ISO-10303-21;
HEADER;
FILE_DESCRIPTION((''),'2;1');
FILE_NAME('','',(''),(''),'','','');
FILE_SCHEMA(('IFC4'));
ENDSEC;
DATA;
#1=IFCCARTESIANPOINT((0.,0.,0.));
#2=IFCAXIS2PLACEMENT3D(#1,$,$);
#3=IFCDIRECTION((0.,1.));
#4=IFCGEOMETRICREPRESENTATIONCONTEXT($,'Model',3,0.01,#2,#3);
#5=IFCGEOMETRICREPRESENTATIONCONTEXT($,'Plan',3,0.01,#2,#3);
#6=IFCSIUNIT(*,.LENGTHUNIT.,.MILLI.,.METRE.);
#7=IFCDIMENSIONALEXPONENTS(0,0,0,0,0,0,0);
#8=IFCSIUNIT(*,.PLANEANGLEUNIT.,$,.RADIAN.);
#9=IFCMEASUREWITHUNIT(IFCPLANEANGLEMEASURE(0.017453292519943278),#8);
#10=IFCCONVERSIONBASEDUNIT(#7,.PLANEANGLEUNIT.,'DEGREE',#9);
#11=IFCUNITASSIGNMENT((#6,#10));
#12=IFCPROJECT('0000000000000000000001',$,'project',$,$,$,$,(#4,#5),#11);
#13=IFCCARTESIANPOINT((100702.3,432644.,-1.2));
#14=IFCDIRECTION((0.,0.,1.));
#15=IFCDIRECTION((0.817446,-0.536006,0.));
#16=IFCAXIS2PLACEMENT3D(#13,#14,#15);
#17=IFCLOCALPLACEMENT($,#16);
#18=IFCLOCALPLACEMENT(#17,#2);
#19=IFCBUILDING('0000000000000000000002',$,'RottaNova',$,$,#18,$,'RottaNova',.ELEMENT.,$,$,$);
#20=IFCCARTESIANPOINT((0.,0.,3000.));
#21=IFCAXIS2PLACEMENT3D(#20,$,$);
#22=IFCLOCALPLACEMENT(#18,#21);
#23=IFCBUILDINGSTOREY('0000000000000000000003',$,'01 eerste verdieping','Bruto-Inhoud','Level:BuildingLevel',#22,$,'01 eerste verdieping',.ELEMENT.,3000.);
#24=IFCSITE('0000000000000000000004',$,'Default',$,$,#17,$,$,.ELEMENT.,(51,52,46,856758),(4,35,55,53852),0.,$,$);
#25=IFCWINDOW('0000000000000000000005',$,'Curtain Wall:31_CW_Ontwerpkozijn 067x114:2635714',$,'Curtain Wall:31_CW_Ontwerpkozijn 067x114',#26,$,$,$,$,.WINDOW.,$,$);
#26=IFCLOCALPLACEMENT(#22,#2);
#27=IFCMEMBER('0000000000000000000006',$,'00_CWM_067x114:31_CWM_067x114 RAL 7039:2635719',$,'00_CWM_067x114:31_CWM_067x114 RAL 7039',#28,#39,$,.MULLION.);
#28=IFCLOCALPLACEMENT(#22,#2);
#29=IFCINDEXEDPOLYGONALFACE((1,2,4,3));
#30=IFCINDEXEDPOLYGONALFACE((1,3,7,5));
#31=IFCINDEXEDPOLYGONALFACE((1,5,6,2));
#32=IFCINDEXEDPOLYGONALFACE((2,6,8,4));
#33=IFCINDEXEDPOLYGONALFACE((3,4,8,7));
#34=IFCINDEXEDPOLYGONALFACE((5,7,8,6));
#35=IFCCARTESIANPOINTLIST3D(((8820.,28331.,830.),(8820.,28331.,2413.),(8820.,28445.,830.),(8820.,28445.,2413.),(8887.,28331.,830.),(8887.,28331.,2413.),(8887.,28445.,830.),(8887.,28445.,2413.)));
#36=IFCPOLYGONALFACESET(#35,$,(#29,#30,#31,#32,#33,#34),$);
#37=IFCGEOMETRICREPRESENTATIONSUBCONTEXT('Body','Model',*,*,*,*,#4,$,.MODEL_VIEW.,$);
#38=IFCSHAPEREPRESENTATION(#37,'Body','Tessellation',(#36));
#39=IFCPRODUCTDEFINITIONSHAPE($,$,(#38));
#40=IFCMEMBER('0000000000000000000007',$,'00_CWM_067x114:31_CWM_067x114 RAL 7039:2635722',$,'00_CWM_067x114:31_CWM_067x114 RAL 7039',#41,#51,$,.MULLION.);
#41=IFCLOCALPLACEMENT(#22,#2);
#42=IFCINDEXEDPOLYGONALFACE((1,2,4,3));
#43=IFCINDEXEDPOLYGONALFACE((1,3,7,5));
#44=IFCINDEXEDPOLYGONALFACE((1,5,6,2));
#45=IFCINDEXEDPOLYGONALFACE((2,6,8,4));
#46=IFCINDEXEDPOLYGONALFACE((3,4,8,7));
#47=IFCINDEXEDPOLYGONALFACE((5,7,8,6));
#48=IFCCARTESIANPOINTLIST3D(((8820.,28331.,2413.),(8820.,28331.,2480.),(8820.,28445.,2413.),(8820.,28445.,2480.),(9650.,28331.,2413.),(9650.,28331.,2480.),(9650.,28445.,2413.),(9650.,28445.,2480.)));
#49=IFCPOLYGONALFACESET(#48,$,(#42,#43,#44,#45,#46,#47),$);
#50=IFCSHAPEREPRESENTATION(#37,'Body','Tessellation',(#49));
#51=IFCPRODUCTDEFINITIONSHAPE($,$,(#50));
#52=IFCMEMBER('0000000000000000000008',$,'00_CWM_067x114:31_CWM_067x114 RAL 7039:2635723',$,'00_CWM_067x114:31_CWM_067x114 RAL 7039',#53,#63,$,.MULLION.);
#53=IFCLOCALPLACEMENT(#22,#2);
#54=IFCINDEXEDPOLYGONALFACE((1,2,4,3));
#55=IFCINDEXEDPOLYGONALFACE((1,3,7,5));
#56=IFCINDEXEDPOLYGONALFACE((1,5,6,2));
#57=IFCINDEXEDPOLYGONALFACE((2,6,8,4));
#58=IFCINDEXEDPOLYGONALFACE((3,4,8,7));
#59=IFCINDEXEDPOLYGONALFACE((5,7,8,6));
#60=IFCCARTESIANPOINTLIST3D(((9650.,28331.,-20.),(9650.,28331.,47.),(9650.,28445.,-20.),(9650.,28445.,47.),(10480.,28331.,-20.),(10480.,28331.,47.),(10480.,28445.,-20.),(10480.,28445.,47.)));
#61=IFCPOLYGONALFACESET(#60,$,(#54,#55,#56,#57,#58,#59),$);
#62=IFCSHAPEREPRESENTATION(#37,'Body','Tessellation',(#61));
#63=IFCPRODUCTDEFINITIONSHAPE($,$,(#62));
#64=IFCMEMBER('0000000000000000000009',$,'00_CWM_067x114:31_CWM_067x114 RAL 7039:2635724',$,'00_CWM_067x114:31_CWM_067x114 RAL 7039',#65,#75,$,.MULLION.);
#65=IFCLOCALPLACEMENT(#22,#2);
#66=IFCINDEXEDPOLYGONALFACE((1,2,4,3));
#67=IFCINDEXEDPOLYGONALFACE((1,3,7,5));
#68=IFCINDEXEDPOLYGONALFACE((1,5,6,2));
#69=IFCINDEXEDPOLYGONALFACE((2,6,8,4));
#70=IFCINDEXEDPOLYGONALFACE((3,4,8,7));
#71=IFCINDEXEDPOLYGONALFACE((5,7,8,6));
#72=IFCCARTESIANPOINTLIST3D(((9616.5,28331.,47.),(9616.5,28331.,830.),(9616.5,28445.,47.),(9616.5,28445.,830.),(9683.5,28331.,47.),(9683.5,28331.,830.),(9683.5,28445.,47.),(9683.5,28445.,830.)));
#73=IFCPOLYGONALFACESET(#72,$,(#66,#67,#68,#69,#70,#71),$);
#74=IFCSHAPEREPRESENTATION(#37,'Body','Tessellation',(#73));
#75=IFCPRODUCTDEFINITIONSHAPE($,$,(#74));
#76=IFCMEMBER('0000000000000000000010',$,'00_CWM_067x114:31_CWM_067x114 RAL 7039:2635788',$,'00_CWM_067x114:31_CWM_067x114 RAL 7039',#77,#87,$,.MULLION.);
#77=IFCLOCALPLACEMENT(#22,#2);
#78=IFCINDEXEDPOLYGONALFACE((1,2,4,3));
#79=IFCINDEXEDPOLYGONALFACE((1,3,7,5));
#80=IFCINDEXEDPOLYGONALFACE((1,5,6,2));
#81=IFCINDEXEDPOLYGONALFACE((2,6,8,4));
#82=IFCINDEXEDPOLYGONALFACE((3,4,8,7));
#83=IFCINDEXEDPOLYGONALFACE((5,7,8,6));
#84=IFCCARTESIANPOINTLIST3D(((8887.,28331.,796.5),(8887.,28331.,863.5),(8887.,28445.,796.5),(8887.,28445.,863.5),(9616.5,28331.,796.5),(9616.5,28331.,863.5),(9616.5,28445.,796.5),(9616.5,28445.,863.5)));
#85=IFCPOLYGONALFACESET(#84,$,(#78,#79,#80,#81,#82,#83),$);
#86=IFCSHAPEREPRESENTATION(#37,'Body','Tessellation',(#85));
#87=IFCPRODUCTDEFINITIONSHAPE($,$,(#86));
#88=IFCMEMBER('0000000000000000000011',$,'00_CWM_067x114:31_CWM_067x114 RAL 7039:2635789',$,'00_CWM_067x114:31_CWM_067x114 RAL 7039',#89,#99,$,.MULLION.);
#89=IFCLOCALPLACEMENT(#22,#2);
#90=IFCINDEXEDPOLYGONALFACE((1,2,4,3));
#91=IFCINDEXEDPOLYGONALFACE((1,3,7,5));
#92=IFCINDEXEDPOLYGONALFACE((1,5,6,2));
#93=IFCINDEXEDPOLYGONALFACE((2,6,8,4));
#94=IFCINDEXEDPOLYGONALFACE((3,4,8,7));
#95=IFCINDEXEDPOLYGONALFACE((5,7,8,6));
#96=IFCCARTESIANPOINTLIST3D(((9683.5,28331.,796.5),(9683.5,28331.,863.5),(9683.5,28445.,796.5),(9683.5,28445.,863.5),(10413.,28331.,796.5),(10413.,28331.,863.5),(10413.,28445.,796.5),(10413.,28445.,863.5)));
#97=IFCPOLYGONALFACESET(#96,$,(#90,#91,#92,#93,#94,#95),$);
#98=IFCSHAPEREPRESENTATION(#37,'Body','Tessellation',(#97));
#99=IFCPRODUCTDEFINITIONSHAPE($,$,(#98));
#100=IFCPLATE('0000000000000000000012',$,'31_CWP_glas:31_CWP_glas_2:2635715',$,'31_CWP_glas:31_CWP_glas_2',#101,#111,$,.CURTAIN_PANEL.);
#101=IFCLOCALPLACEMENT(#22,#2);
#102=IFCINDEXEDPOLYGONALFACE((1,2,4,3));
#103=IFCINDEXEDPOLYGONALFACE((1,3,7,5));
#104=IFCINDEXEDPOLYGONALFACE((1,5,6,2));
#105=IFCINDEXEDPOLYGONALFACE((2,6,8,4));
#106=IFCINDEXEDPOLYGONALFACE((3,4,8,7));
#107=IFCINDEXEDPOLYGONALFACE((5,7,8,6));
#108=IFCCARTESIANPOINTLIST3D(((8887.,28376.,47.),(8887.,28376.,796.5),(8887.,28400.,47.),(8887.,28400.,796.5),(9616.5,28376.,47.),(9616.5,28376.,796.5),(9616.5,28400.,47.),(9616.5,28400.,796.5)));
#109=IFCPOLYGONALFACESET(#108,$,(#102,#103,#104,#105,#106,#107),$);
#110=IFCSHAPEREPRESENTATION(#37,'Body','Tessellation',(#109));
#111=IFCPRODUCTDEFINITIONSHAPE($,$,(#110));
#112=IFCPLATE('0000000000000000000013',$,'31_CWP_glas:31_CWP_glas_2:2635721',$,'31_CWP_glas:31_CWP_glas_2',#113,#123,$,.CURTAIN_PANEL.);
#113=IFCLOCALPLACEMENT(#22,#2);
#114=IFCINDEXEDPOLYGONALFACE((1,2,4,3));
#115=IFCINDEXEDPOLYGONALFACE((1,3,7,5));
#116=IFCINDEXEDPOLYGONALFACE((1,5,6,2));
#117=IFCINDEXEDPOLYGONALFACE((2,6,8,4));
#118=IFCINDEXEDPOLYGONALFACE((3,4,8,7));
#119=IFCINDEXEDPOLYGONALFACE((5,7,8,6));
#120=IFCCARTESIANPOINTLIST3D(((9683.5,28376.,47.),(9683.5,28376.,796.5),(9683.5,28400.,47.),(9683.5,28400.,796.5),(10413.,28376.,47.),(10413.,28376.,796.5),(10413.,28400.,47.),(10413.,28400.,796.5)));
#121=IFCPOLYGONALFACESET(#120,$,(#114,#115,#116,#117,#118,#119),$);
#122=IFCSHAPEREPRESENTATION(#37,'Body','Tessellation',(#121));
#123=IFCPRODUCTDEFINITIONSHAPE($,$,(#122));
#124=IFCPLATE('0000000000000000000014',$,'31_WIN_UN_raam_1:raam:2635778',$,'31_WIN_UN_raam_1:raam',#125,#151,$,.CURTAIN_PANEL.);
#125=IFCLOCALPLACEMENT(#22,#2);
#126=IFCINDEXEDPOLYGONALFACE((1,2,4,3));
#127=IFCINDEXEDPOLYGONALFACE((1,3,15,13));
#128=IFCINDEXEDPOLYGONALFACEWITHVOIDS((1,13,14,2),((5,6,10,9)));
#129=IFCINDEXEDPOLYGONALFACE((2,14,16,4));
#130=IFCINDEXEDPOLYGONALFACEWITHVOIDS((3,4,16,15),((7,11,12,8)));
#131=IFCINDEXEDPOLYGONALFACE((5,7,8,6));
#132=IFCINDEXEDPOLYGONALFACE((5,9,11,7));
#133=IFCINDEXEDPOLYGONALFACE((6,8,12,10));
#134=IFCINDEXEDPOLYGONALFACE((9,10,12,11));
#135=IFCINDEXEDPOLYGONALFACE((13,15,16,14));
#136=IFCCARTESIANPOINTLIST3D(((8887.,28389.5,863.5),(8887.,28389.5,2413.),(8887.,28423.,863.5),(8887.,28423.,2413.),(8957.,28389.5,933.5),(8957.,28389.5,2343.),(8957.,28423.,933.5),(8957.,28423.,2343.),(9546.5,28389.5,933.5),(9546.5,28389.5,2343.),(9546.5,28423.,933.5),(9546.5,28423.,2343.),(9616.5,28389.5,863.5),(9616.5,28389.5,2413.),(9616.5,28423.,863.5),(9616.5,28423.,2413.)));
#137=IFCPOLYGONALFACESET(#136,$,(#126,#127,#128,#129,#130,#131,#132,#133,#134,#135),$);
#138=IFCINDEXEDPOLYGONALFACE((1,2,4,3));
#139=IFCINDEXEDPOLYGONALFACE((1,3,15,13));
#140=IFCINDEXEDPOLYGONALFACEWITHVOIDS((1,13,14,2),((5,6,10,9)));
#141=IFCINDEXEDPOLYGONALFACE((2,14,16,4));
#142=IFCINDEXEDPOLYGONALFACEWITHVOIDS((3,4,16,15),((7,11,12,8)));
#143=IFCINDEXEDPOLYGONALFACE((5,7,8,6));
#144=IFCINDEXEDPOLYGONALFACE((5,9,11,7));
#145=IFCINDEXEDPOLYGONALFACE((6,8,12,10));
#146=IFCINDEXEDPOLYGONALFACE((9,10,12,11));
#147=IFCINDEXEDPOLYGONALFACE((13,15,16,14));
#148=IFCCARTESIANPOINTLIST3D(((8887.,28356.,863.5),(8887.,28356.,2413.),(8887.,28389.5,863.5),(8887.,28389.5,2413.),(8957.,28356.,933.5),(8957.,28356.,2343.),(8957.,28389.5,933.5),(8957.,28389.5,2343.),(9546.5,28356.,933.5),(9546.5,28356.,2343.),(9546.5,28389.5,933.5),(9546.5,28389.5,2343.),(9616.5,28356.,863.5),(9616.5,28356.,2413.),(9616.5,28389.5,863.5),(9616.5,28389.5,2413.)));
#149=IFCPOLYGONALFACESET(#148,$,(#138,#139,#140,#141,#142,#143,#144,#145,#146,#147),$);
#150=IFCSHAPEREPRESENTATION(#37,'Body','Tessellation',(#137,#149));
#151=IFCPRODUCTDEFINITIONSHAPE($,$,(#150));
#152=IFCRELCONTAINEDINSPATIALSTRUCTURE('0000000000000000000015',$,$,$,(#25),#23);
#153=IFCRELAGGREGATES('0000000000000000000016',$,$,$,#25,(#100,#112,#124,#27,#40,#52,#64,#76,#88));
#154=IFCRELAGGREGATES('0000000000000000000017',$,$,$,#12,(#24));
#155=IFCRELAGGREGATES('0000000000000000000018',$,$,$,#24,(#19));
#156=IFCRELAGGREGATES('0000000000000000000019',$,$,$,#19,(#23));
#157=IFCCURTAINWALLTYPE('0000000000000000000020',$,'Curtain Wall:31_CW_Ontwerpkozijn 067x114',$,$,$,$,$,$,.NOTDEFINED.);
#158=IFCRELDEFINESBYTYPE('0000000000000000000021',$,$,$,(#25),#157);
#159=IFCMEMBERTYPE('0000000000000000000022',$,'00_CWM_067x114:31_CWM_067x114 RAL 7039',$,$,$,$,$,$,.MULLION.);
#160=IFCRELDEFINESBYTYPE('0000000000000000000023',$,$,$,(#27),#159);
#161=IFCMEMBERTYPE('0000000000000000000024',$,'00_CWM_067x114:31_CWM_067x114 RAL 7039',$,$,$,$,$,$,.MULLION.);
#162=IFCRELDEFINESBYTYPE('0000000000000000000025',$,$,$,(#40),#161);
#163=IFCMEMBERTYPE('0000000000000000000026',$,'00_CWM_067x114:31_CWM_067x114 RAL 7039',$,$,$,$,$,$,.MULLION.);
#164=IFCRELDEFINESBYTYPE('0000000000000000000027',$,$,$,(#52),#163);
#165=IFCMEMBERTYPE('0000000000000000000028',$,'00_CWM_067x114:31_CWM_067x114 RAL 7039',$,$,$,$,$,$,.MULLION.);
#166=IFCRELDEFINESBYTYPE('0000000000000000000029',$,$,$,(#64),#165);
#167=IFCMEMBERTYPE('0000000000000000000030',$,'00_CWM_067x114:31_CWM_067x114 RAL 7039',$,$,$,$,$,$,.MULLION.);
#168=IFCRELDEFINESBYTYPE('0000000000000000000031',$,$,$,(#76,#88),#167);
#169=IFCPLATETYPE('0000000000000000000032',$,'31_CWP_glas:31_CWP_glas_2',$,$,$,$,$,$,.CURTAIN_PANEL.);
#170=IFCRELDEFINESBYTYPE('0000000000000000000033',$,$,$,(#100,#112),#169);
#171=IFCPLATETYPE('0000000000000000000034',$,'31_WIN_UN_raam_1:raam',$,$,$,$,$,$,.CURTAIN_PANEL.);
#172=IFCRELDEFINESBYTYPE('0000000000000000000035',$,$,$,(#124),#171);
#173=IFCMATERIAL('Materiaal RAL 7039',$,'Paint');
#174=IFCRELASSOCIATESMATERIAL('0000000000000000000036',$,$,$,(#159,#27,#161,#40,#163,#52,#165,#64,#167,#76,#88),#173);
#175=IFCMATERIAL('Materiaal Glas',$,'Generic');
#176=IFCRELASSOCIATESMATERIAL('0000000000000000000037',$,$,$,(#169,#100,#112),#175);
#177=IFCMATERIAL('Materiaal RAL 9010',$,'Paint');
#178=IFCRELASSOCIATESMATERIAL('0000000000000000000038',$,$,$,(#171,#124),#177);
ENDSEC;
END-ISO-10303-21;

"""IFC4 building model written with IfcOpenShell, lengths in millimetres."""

from ifc_helpers import new_model, entity, si_unit, converted_unit, direction, frame, origin, place, context, subcontext, project, spatial, indexed_curve, outline, extrude, source, transform, mapped, material, type_object, type_shapes, element, aggregate, save


model = new_model("IFC4")

# Units and contexts
model_context = context("Model", 3, precision=0.01, world=origin(), true_north=direction((0.0, 1.0)))
plan_context = context("Plan", 3, precision=0.01, world=origin(), true_north=direction((0.0, 1.0)))
body_context = subcontext(model_context, "Body", "Model", "MODEL_VIEW")
ifc_project = project(units=[si_unit("LENGTHUNIT", "METRE", prefix="MILLI"), converted_unit("PLANEANGLEUNIT", "DEGREE", entity("IfcPlaneAngleMeasure", 0.017453292519943278), si_unit("PLANEANGLEUNIT", "RADIAN"), dimensions=[0, 0, 0, 0, 0, 0, 0])], contexts=[model_context, plan_context])

# Site, building, storey
site_placement = place(None, frame((100702.3, 432644.0, -1.2), z_axis=(0.0, 0.0, 1.0), x_axis=(0.817446, -0.536006, 0.0)))
site = spatial("IfcSite", under=ifc_project, at=site_placement, Name="Default", CompositionType="ELEMENT", RefLatitude=(51, 52, 46, 856758), RefLongitude=(4, 35, 55, 53852), RefElevation=0.0)
building_placement = place(site_placement, origin())
building = spatial("IfcBuilding", under=site, at=building_placement, Name="RottaNova", LongName="RottaNova", CompositionType="ELEMENT")
storey_placement = place(building_placement, frame((0.0, 0.0, 3000.0)))
storey = spatial("IfcBuildingStorey", under=building, at=storey_placement, Name="01 eerste verdieping", Description="Bruto-Inhoud", ObjectType="Level:BuildingLevel", LongName="01 eerste verdieping", CompositionType="ELEMENT", Elevation=3000.0)

# Shared definitions
curtain_wall_type = type_object("IfcCurtainWallType", Name="Curtain Wall:31_CW_Ontwerpkozijn 067x114", PredefinedType="NOTDEFINED")
ifc_material_1 = material(Name="Materiaal RAL 7039", Category="Paint")

# Window
window_1_placement = place(storey_placement, frame((0.0, 0.0, -3000.0)))
window_1 = element("IfcWindow", 1, at=window_1_placement, inside=storey, type_object=curtain_wall_type, Name="Curtain Wall:31_CW_Ontwerpkozijn 067x114:2635714", ObjectType="Curtain Wall:31_CW_Ontwerpkozijn 067x114", PredefinedType="WINDOW")

# Members
member_type_1 = type_object("IfcMemberType", Name="00_CWM_067x114:31_CWM_067x114 RAL 7039", PredefinedType="MULLION", material=ifc_material_1)
shared_shape_1 = source(origin(), body_context, "Body", "SweptSolid", [
    extrude(outline(indexed_curve([(-33.5, -57.0), (33.5, -57.0), (33.5, 57.0), (-33.5, 57.0), (-33.5, -57.0)], self_intersect=False)), frame((-33.5, -57.0, -1583.0), z_axis=(0.0, 0.0, 1.0), x_axis=(-1.0, 0.0, 0.0)), (0.0, 0.0, 1.0), 1583.0),
])
type_shapes(member_type_1, [shared_shape_1])
member_1_placement = place(window_1_placement, frame((8820.0, 28331.0, 5413.0), z_axis=(0.0, 0.0, 1.0), x_axis=(-1.0, 0.0, 0.0)))
member_1 = element("IfcMember", 2, at=member_1_placement, type_object=member_type_1, material=ifc_material_1, Name="00_CWM_067x114:31_CWM_067x114 RAL 7039:2635719", ObjectType="00_CWM_067x114:31_CWM_067x114 RAL 7039", PredefinedType="MULLION", context=body_context, shape_type="MappedRepresentation", body=[
    mapped(shared_shape_1, transform((0.0, 0.0, 0.0), scale=1.0)),
])
member_type_2 = type_object("IfcMemberType", Name="00_CWM_067x114:31_CWM_067x114 RAL 7039", PredefinedType="MULLION", material=ifc_material_1)
shared_shape_2 = source(origin(), body_context, "Body", "SweptSolid", [
    extrude(outline(indexed_curve([(-33.5, -57.0), (33.5, -57.0), (33.5, 57.0), (-33.5, 57.0), (-33.5, -57.0)], self_intersect=False)), frame((-33.5, -57.0, -830.0), z_axis=(0.0, 0.0, 1.0), x_axis=(-1.0, 0.0, 0.0)), (0.0, 0.0, 1.0), 830.0),
])
type_shapes(member_type_2, [shared_shape_2])
member_2_placement = place(window_1_placement, frame((9650.0, 28331.0, 5480.0), z_axis=(1.0, 0.0, 0.0), x_axis=(0.0, 0.0, 1.0)))
member_2 = element("IfcMember", 3, at=member_2_placement, type_object=member_type_2, material=ifc_material_1, Name="00_CWM_067x114:31_CWM_067x114 RAL 7039:2635722", ObjectType="00_CWM_067x114:31_CWM_067x114 RAL 7039", PredefinedType="MULLION", context=body_context, shape_type="MappedRepresentation", body=[
    mapped(shared_shape_2, transform((0.0, 0.0, 0.0), scale=1.0)),
])
member_type_3 = type_object("IfcMemberType", Name="00_CWM_067x114:31_CWM_067x114 RAL 7039", PredefinedType="MULLION", material=ifc_material_1)
shared_shape_3 = source(origin(), body_context, "Body", "SweptSolid", [
    extrude(outline(indexed_curve([(-33.5, -57.0), (33.5, -57.0), (33.5, 57.0), (-33.5, 57.0), (-33.5, -57.0)], self_intersect=False)), frame((-33.5, -57.0, -830.0), z_axis=(0.0, 0.0, 1.0), x_axis=(-1.0, 0.0, 0.0)), (0.0, 0.0, 1.0), 830.0),
])
type_shapes(member_type_3, [shared_shape_3])
member_3_placement = place(window_1_placement, frame((9650.0, 28331.0, 2980.0), z_axis=(-1.0, 0.0, 0.0), x_axis=(0.0, 0.0, -1.0)))
member_3 = element("IfcMember", 4, at=member_3_placement, type_object=member_type_3, material=ifc_material_1, Name="00_CWM_067x114:31_CWM_067x114 RAL 7039:2635723", ObjectType="00_CWM_067x114:31_CWM_067x114 RAL 7039", PredefinedType="MULLION", context=body_context, shape_type="MappedRepresentation", body=[
    mapped(shared_shape_3, transform((0.0, 0.0, 0.0), scale=1.0)),
])
member_type_4 = type_object("IfcMemberType", Name="00_CWM_067x114:31_CWM_067x114 RAL 7039", PredefinedType="MULLION", material=ifc_material_1)
shared_shape_4 = source(origin(), body_context, "Body", "SweptSolid", [
    extrude(outline(indexed_curve([(-33.5, -57.0), (33.5, -57.0), (33.5, 57.0), (-33.5, 57.0), (-33.5, -57.0)], self_intersect=False)), frame((0.0, -57.0, -783.0), z_axis=(0.0, 0.0, 1.0), x_axis=(-1.0, 0.0, 0.0)), (0.0, 0.0, 1.0), 783.0),
])
type_shapes(member_type_4, [shared_shape_4])
member_4_placement = place(window_1_placement, frame((9650.0, 28331.0, 3047.0), z_axis=(0.0, 0.0, -1.0), x_axis=(1.0, 0.0, 0.0)))
member_4 = element("IfcMember", 5, at=member_4_placement, type_object=member_type_4, material=ifc_material_1, Name="00_CWM_067x114:31_CWM_067x114 RAL 7039:2635724", ObjectType="00_CWM_067x114:31_CWM_067x114 RAL 7039", PredefinedType="MULLION", context=body_context, shape_type="MappedRepresentation", body=[
    mapped(shared_shape_4, transform((0.0, 0.0, 0.0), scale=1.0)),
])
member_type_5 = type_object("IfcMemberType", Name="00_CWM_067x114:31_CWM_067x114 RAL 7039", PredefinedType="MULLION", material=ifc_material_1)
shared_shape_5 = source(origin(), body_context, "Body", "SweptSolid", [
    extrude(outline(indexed_curve([(-33.5, -57.0), (33.5, -57.0), (33.5, 57.0), (-33.5, 57.0), (-33.5, -57.0)], self_intersect=False)), frame((0.0, -57.0, -729.5), z_axis=(0.0, 0.0, 1.0), x_axis=(-1.0, 0.0, 0.0)), (0.0, 0.0, 1.0), 729.5),
])
type_shapes(member_type_5, [shared_shape_5])
member_5_placement = place(window_1_placement, frame((9616.5, 28331.0, 3830.0), z_axis=(1.0, 0.0, 0.0), x_axis=(0.0, 0.0, 1.0)))
member_5 = element("IfcMember", 6, at=member_5_placement, type_object=member_type_5, material=ifc_material_1, Name="00_CWM_067x114:31_CWM_067x114 RAL 7039:2635788", ObjectType="00_CWM_067x114:31_CWM_067x114 RAL 7039", PredefinedType="MULLION", context=body_context, shape_type="MappedRepresentation", body=[
    mapped(shared_shape_5, transform((0.0, 0.0, 0.0), scale=1.0)),
])
member_6_placement = place(window_1_placement, frame((10413.0, 28331.0, 3830.0), z_axis=(1.0, 0.0, 0.0), x_axis=(0.0, 0.0, 1.0)))
member_6 = element("IfcMember", 7, at=member_6_placement, type_object=member_type_5, material=ifc_material_1, Name="00_CWM_067x114:31_CWM_067x114 RAL 7039:2635789", ObjectType="00_CWM_067x114:31_CWM_067x114 RAL 7039", PredefinedType="MULLION", context=body_context, shape_type="MappedRepresentation", body=[
    mapped(shared_shape_5, transform((0.0, 0.0, 0.0), scale=1.0)),
])

# Plates
ifc_material_2 = material(Name="Materiaal Glas", Category="Generic")
plate_type_1 = type_object("IfcPlateType", Name="31_CWP_glas:31_CWP_glas_2", PredefinedType="CURTAIN_PANEL", material=ifc_material_2)
shared_shape_6 = source(origin(), body_context, "Body", "SweptSolid", [
    extrude(outline(indexed_curve([(-12.0, -364.7), (12.0, -364.7), (12.0, 364.7), (-12.0, 364.7), (-12.0, -364.7)], self_intersect=False)), frame((0.0, 57.0, 0.0), z_axis=(0.0, 0.0, 1.0), x_axis=(0.0, 1.0, 0.0)), (0.0, 0.0, 1.0), 749.5),
])
type_shapes(plate_type_1, [shared_shape_6])
plate_1_placement = place(window_1_placement, frame((9251.7, 28331.0, 3047.0)))
plate_1 = element("IfcPlate", 8, at=plate_1_placement, type_object=plate_type_1, material=ifc_material_2, Name="31_CWP_glas:31_CWP_glas_2:2635715", ObjectType="31_CWP_glas:31_CWP_glas_2", PredefinedType="CURTAIN_PANEL", context=body_context, shape_type="MappedRepresentation", body=[
    mapped(shared_shape_6, transform((0.0, 0.0, 0.0), scale=1.0)),
])
plate_2_placement = place(window_1_placement, frame((10048.2, 28331.0, 3047.0)))
plate_2 = element("IfcPlate", 9, at=plate_2_placement, type_object=plate_type_1, material=ifc_material_2, Name="31_CWP_glas:31_CWP_glas_2:2635721", ObjectType="31_CWP_glas:31_CWP_glas_2", PredefinedType="CURTAIN_PANEL", context=body_context, shape_type="MappedRepresentation", body=[
    mapped(shared_shape_6, transform((0.0, 0.0, 0.0), scale=1.0)),
])
ifc_material_3 = material(Name="Materiaal RAL 9010", Category="Paint")
plate_type_2 = type_object("IfcPlateType", Name="31_WIN_UN_raam_1:raam", PredefinedType="CURTAIN_PANEL", material=ifc_material_3)
shared_shape_7 = source(origin(), body_context, "Body", "SweptSolid", [
    extrude(outline(indexed_curve([(-364.7, -774.7), (364.7, -774.7), (364.7, 774.7), (-364.7, 774.7), (-364.7, -774.7)], self_intersect=False), holes=[indexed_curve([(-294.7, 704.7), (294.7, 704.7), (294.7, -704.8), (-294.7, -704.8), (-294.7, 704.7)], self_intersect=False)]), frame((0.0, 58.5, 774.8), z_axis=(0.0, 1.0, 0.0), x_axis=(1.0, 0.0, 0.0)), (0.0, 0.0, 1.0), 33.5),
    extrude(outline(indexed_curve([(-364.7, -774.7), (364.7, -774.7), (364.7, 774.7), (-364.7, 774.7), (-364.7, -774.7)], self_intersect=False), holes=[indexed_curve([(-294.7, 704.7), (294.7, 704.7), (294.7, -704.8), (-294.7, -704.8), (-294.7, 704.7)], self_intersect=False)]), frame((0.0, 25.0, 774.8), z_axis=(0.0, 1.0, 0.0), x_axis=(1.0, 0.0, 0.0)), (0.0, 0.0, 1.0), 33.5),
])
type_shapes(plate_type_2, [shared_shape_7])
plate_3_placement = place(window_1_placement, frame((9251.7, 28331.0, 3863.5)))
plate_3 = element("IfcPlate", 10, at=plate_3_placement, type_object=plate_type_2, material=ifc_material_3, Name="31_WIN_UN_raam_1:raam:2635778", ObjectType="31_WIN_UN_raam_1:raam", PredefinedType="CURTAIN_PANEL", context=body_context, shape_type="MappedRepresentation", body=[
    mapped(shared_shape_7, transform((0.0, 0.0, 0.0), scale=1.0)),
])
aggregate(window_1, [plate_1, plate_2, plate_3, member_1, member_2, member_3, member_4, member_5, member_6])

save(model, "model.ifc")
